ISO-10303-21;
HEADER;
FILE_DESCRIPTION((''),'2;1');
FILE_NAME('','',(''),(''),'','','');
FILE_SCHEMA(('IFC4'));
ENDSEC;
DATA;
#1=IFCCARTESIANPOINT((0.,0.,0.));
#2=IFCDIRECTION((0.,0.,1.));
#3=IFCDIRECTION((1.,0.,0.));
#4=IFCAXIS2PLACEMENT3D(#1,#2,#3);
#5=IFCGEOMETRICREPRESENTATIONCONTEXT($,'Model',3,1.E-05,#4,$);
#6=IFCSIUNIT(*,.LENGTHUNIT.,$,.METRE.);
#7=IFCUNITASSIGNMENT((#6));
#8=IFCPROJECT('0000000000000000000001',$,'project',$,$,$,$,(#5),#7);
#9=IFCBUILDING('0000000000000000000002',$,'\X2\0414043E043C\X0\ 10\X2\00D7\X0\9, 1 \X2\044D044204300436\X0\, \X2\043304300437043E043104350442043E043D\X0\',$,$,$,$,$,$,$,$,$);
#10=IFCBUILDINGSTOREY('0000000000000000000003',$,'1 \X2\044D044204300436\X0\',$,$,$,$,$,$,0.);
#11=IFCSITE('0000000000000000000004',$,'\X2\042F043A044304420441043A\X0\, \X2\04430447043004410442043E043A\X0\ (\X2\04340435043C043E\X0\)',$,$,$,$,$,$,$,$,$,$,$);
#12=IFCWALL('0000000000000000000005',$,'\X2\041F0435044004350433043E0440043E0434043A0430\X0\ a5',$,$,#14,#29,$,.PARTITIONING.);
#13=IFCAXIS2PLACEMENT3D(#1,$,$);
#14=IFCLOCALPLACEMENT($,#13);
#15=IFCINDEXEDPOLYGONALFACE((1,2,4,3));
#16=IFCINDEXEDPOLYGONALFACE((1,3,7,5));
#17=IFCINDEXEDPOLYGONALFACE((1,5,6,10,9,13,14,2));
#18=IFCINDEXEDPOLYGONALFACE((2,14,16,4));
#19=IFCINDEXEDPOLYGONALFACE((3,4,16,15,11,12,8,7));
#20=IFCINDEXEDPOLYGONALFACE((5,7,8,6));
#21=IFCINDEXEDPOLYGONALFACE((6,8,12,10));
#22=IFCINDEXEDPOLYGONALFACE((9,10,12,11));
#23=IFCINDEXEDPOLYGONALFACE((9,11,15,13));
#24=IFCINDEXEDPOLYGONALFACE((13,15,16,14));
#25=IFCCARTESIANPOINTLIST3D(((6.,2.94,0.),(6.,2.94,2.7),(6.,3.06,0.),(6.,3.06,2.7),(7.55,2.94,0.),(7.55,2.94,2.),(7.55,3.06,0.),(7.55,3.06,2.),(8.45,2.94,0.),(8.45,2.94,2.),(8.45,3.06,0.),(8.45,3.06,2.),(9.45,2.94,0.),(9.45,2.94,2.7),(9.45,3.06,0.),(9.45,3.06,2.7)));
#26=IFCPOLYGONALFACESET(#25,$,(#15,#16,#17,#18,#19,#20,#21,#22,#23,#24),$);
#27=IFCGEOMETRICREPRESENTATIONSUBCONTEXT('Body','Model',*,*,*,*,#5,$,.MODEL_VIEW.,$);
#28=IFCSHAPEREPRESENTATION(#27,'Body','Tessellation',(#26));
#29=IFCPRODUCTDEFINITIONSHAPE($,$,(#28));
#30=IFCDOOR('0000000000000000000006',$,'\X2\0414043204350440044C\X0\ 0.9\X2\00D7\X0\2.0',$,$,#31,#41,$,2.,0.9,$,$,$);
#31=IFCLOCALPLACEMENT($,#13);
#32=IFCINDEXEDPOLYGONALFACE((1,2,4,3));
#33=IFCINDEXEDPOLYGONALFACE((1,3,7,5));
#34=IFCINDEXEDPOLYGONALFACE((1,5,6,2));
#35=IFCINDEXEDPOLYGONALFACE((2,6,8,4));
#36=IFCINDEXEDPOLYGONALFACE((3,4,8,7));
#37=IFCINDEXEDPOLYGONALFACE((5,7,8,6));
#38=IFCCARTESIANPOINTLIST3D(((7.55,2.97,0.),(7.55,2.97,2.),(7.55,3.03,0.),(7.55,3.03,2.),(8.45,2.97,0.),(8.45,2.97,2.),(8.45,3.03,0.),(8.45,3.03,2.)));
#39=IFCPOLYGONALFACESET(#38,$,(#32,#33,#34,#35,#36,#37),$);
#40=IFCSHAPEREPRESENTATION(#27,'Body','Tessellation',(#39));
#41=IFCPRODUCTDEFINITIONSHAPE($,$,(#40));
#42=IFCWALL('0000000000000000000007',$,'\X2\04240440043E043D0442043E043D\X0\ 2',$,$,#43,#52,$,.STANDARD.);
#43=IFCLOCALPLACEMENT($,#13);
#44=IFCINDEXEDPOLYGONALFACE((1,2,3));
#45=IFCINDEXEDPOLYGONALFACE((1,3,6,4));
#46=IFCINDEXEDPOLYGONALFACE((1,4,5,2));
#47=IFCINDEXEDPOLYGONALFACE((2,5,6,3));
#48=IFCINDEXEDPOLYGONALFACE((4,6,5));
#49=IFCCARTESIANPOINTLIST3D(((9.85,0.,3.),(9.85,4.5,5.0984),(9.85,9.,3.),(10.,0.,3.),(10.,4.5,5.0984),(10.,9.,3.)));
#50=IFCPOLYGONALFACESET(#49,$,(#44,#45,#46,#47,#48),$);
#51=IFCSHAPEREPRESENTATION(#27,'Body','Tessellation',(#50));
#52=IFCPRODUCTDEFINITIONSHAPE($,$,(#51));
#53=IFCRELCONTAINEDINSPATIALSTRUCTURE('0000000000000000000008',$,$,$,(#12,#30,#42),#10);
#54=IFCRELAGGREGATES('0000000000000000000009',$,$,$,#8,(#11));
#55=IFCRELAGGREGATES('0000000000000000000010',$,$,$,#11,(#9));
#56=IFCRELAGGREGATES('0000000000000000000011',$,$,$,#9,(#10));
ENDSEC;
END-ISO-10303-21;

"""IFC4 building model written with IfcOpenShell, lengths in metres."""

from ifc_helpers import new_model, si_unit, frame, origin_with_axes, place, context, subcontext, project, spatial, polyline, indexed_curve, outline, extrude, element, fill, save


model = new_model("IFC4")

# Units and contexts
model_context = context("Model", 3, precision=1e-05, world=origin_with_axes())
body_context = subcontext(model_context, "Body", "Model", "MODEL_VIEW")
ifc_project = project(units=[si_unit("LENGTHUNIT", "METRE")], contexts=[model_context])

# Site, building, storey
site = spatial("IfcSite", under=ifc_project, Name="Якутск, участок (демо)")
building = spatial("IfcBuilding", under=site, Name="Дом 10×9, 1 этаж, газобетон")
storey = spatial("IfcBuildingStorey", under=building, Name="1 этаж", Elevation=0.0)

# Wall, opening, door
wall_1_placement = place(None, frame((6.0, 2.94, 0.0), z_axis=(0.0, 0.0, 1.0), x_axis=(1.0, 0.0, 0.0)))
wall_1 = element("IfcWall", 1, at=wall_1_placement, inside=storey, Name="Перегородка a5", PredefinedType="PARTITIONING", context=body_context, shape_type="SweptSolid", body=[
    extrude(outline(indexed_curve([(0.0, 0.0), (0.0, 0.12), (3.45, 0.12), (3.45, 0.0), (0.0, 0.0)], self_intersect=False)), origin_with_axes(), (0.0, 0.0, 1.0), 2.7),
])
opening_1_placement = place(wall_1_placement, frame((1.55, -0.05, 0.0), z_axis=(0.0, 0.0, 1.0), x_axis=(1.0, 0.0, 0.0)))
opening_1 = element("IfcOpeningElement", 2, at=opening_1_placement, cuts=wall_1, context=body_context, shape_type="SweptSolid", body=[
    extrude(outline(indexed_curve([(0.0, 0.0), (0.0, 0.22), (0.9, 0.22), (0.9, 0.0), (0.0, 0.0)], self_intersect=False)), origin_with_axes(), (0.0, 0.0, 1.0), 2.0),
])
door_1_placement = place(opening_1_placement, frame((0.0, 0.08, 0.0), z_axis=(0.0, 0.0, 1.0), x_axis=(1.0, 0.0, 0.0)))
door_1 = element("IfcDoor", 3, at=door_1_placement, inside=storey, Name="Дверь 0.9×2.0", OverallHeight=2.0, OverallWidth=0.9, context=body_context, shape_type="SweptSolid", body=[
    extrude(outline(indexed_curve([(0.0, 0.0), (0.0, 0.06), (0.9, 0.06), (0.9, 0.0), (0.0, 0.0)], self_intersect=False)), origin_with_axes(), (0.0, 0.0, 1.0), 2.0),
])
fill(opening_1, door_1)

# Wall
wall_2_placement = place(None, frame((9.85, 0.0, 3.0), z_axis=(1.0, 0.0, 0.0), x_axis=(0.0, 1.0, 0.0)))
element("IfcWall", 4, at=wall_2_placement, inside=storey, Name="Фронтон 2", PredefinedType="STANDARD", context=body_context, shape_type="SweptSolid", body=[
    extrude(outline(polyline([(0.0, 0.0), (9.0, 0.0), (4.5, 2.0984), (0.0, 0.0)])), origin_with_axes(), (0.0, 0.0, 1.0), 0.15),
])

save(model, "model.ifc")
